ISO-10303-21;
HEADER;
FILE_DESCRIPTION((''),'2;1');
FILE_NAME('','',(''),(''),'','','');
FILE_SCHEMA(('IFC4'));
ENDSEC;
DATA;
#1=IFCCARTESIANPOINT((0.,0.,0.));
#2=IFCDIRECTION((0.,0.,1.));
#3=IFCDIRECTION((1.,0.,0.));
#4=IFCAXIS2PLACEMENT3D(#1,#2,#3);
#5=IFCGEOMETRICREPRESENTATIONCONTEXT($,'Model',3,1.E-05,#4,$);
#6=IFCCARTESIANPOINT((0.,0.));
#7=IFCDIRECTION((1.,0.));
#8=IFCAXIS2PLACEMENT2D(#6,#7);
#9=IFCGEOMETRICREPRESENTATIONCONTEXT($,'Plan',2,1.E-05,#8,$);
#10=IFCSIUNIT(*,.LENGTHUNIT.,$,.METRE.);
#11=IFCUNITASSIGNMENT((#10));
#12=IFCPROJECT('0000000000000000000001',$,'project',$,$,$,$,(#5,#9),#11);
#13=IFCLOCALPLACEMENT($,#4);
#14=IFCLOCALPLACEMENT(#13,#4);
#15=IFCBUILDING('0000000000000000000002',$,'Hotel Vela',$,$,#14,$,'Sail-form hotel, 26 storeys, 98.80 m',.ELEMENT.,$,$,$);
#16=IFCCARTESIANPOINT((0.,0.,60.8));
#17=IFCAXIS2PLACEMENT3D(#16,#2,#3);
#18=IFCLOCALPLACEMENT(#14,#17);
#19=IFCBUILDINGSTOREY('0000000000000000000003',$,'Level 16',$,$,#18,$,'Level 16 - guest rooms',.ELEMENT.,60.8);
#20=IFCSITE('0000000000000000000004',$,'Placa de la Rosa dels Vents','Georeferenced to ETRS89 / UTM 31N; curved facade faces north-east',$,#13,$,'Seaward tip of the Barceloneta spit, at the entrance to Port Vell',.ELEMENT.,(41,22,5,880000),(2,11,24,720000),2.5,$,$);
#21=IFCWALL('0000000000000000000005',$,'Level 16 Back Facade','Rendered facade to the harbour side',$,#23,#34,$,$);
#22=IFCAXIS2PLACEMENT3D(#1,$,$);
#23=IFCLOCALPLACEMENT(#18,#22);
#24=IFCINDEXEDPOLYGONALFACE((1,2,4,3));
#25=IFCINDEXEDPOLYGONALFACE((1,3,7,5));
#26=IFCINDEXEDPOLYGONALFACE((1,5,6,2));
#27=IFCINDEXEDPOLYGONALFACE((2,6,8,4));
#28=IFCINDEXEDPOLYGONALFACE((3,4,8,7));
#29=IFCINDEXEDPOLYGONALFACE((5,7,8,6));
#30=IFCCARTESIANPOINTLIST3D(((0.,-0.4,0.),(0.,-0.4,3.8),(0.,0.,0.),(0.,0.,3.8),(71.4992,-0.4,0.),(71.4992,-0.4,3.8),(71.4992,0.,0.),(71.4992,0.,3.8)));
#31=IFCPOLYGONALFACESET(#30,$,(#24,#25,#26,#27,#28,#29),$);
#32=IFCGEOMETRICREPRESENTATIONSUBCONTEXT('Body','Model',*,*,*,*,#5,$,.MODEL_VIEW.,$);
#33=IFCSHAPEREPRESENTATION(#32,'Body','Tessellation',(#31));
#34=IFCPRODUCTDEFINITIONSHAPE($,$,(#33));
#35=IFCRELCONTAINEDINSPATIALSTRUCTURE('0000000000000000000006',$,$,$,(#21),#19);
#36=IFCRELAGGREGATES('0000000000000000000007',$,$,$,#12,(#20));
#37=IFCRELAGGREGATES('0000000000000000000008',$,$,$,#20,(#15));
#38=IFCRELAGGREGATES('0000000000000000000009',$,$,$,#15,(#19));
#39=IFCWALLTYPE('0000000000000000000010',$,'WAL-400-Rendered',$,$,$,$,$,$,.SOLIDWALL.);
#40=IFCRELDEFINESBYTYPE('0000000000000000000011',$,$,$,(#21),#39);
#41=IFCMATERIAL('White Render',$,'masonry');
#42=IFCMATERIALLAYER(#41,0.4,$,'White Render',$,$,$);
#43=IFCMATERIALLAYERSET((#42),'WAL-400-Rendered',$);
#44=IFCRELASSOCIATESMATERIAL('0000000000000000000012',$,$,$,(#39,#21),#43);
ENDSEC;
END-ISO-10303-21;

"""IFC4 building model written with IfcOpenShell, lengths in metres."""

from ifc_helpers import new_model, si_unit, frame, origin_with_axes, origin_2d_with_axis, place, context, subcontext, project, spatial, line, indexed_curve, outline, extrude, material, layer, layer_set, layer_usage, type_object, element, save


model = new_model("IFC4")

# Units and contexts
model_context = context("Model", 3, precision=1e-05, world=origin_with_axes())
plan_context = context("Plan", 2, precision=1e-05, world=origin_2d_with_axis())
body_context = subcontext(model_context, "Body", "Model", "MODEL_VIEW")
ifc_project = project(units=[si_unit("LENGTHUNIT", "METRE")], contexts=[model_context, plan_context])

# Site, building, storey
site_placement = place(None, origin_with_axes())
site = spatial("IfcSite", under=ifc_project, at=site_placement, Name="Placa de la Rosa dels Vents", Description="Georeferenced to ETRS89 / UTM 31N; curved facade faces north-east", LongName="Seaward tip of the Barceloneta spit, at the entrance to Port Vell", CompositionType="ELEMENT", RefLatitude=(41, 22, 5, 880000), RefLongitude=(2, 11, 24, 720000), RefElevation=2.5)
building_placement = place(site_placement, origin_with_axes())
building = spatial("IfcBuilding", under=site, at=building_placement, Name="Hotel Vela", LongName="Sail-form hotel, 26 storeys, 98.80 m", CompositionType="ELEMENT")
storey_placement = place(building_placement, frame((0.0, 0.0, 60.8), z_axis=(0.0, 0.0, 1.0), x_axis=(1.0, 0.0, 0.0)))
storey = spatial("IfcBuildingStorey", under=building, at=storey_placement, Name="Level 16", LongName="Level 16 - guest rooms", CompositionType="ELEMENT", Elevation=60.8)

# Wall
ifc_material_1 = material(Name="White Render", Category="masonry")
ifc_layer_1 = layer(ifc_material_1, 0.4, Name="White Render")
ifc_layer_set_1 = layer_set([ifc_layer_1], Name="WAL-400-Rendered")
ifc_layer_usage_1 = layer_usage(ifc_layer_set_1, "AXIS2", "POSITIVE", 0.0)
wall_type = type_object("IfcWallType", Name="WAL-400-Rendered", PredefinedType="SOLIDWALL", material=ifc_layer_set_1)
wall_placement = place(storey_placement, frame((0.0, -0.4, 0.0), z_axis=(0.0, 0.0, 1.0), x_axis=(1.0, 0.0, 0.0)))
element("IfcWall", 1, at=wall_placement, inside=storey, type_object=wall_type, material=ifc_layer_usage_1, Name="Level 16 Back Facade", Description="Rendered facade to the harbour side", context=body_context, shape_type="SweptSolid", body=[
    extrude(outline(indexed_curve([(0.0, 0.0), (71.4992, 0.0), (71.4992, 0.4), (0.0, 0.4)], segments=[line(1, 2, 3, 4, 1)])), origin_with_axes(), (0.0, 0.0, 1.0), 3.8),
])

save(model, "model.ifc")
